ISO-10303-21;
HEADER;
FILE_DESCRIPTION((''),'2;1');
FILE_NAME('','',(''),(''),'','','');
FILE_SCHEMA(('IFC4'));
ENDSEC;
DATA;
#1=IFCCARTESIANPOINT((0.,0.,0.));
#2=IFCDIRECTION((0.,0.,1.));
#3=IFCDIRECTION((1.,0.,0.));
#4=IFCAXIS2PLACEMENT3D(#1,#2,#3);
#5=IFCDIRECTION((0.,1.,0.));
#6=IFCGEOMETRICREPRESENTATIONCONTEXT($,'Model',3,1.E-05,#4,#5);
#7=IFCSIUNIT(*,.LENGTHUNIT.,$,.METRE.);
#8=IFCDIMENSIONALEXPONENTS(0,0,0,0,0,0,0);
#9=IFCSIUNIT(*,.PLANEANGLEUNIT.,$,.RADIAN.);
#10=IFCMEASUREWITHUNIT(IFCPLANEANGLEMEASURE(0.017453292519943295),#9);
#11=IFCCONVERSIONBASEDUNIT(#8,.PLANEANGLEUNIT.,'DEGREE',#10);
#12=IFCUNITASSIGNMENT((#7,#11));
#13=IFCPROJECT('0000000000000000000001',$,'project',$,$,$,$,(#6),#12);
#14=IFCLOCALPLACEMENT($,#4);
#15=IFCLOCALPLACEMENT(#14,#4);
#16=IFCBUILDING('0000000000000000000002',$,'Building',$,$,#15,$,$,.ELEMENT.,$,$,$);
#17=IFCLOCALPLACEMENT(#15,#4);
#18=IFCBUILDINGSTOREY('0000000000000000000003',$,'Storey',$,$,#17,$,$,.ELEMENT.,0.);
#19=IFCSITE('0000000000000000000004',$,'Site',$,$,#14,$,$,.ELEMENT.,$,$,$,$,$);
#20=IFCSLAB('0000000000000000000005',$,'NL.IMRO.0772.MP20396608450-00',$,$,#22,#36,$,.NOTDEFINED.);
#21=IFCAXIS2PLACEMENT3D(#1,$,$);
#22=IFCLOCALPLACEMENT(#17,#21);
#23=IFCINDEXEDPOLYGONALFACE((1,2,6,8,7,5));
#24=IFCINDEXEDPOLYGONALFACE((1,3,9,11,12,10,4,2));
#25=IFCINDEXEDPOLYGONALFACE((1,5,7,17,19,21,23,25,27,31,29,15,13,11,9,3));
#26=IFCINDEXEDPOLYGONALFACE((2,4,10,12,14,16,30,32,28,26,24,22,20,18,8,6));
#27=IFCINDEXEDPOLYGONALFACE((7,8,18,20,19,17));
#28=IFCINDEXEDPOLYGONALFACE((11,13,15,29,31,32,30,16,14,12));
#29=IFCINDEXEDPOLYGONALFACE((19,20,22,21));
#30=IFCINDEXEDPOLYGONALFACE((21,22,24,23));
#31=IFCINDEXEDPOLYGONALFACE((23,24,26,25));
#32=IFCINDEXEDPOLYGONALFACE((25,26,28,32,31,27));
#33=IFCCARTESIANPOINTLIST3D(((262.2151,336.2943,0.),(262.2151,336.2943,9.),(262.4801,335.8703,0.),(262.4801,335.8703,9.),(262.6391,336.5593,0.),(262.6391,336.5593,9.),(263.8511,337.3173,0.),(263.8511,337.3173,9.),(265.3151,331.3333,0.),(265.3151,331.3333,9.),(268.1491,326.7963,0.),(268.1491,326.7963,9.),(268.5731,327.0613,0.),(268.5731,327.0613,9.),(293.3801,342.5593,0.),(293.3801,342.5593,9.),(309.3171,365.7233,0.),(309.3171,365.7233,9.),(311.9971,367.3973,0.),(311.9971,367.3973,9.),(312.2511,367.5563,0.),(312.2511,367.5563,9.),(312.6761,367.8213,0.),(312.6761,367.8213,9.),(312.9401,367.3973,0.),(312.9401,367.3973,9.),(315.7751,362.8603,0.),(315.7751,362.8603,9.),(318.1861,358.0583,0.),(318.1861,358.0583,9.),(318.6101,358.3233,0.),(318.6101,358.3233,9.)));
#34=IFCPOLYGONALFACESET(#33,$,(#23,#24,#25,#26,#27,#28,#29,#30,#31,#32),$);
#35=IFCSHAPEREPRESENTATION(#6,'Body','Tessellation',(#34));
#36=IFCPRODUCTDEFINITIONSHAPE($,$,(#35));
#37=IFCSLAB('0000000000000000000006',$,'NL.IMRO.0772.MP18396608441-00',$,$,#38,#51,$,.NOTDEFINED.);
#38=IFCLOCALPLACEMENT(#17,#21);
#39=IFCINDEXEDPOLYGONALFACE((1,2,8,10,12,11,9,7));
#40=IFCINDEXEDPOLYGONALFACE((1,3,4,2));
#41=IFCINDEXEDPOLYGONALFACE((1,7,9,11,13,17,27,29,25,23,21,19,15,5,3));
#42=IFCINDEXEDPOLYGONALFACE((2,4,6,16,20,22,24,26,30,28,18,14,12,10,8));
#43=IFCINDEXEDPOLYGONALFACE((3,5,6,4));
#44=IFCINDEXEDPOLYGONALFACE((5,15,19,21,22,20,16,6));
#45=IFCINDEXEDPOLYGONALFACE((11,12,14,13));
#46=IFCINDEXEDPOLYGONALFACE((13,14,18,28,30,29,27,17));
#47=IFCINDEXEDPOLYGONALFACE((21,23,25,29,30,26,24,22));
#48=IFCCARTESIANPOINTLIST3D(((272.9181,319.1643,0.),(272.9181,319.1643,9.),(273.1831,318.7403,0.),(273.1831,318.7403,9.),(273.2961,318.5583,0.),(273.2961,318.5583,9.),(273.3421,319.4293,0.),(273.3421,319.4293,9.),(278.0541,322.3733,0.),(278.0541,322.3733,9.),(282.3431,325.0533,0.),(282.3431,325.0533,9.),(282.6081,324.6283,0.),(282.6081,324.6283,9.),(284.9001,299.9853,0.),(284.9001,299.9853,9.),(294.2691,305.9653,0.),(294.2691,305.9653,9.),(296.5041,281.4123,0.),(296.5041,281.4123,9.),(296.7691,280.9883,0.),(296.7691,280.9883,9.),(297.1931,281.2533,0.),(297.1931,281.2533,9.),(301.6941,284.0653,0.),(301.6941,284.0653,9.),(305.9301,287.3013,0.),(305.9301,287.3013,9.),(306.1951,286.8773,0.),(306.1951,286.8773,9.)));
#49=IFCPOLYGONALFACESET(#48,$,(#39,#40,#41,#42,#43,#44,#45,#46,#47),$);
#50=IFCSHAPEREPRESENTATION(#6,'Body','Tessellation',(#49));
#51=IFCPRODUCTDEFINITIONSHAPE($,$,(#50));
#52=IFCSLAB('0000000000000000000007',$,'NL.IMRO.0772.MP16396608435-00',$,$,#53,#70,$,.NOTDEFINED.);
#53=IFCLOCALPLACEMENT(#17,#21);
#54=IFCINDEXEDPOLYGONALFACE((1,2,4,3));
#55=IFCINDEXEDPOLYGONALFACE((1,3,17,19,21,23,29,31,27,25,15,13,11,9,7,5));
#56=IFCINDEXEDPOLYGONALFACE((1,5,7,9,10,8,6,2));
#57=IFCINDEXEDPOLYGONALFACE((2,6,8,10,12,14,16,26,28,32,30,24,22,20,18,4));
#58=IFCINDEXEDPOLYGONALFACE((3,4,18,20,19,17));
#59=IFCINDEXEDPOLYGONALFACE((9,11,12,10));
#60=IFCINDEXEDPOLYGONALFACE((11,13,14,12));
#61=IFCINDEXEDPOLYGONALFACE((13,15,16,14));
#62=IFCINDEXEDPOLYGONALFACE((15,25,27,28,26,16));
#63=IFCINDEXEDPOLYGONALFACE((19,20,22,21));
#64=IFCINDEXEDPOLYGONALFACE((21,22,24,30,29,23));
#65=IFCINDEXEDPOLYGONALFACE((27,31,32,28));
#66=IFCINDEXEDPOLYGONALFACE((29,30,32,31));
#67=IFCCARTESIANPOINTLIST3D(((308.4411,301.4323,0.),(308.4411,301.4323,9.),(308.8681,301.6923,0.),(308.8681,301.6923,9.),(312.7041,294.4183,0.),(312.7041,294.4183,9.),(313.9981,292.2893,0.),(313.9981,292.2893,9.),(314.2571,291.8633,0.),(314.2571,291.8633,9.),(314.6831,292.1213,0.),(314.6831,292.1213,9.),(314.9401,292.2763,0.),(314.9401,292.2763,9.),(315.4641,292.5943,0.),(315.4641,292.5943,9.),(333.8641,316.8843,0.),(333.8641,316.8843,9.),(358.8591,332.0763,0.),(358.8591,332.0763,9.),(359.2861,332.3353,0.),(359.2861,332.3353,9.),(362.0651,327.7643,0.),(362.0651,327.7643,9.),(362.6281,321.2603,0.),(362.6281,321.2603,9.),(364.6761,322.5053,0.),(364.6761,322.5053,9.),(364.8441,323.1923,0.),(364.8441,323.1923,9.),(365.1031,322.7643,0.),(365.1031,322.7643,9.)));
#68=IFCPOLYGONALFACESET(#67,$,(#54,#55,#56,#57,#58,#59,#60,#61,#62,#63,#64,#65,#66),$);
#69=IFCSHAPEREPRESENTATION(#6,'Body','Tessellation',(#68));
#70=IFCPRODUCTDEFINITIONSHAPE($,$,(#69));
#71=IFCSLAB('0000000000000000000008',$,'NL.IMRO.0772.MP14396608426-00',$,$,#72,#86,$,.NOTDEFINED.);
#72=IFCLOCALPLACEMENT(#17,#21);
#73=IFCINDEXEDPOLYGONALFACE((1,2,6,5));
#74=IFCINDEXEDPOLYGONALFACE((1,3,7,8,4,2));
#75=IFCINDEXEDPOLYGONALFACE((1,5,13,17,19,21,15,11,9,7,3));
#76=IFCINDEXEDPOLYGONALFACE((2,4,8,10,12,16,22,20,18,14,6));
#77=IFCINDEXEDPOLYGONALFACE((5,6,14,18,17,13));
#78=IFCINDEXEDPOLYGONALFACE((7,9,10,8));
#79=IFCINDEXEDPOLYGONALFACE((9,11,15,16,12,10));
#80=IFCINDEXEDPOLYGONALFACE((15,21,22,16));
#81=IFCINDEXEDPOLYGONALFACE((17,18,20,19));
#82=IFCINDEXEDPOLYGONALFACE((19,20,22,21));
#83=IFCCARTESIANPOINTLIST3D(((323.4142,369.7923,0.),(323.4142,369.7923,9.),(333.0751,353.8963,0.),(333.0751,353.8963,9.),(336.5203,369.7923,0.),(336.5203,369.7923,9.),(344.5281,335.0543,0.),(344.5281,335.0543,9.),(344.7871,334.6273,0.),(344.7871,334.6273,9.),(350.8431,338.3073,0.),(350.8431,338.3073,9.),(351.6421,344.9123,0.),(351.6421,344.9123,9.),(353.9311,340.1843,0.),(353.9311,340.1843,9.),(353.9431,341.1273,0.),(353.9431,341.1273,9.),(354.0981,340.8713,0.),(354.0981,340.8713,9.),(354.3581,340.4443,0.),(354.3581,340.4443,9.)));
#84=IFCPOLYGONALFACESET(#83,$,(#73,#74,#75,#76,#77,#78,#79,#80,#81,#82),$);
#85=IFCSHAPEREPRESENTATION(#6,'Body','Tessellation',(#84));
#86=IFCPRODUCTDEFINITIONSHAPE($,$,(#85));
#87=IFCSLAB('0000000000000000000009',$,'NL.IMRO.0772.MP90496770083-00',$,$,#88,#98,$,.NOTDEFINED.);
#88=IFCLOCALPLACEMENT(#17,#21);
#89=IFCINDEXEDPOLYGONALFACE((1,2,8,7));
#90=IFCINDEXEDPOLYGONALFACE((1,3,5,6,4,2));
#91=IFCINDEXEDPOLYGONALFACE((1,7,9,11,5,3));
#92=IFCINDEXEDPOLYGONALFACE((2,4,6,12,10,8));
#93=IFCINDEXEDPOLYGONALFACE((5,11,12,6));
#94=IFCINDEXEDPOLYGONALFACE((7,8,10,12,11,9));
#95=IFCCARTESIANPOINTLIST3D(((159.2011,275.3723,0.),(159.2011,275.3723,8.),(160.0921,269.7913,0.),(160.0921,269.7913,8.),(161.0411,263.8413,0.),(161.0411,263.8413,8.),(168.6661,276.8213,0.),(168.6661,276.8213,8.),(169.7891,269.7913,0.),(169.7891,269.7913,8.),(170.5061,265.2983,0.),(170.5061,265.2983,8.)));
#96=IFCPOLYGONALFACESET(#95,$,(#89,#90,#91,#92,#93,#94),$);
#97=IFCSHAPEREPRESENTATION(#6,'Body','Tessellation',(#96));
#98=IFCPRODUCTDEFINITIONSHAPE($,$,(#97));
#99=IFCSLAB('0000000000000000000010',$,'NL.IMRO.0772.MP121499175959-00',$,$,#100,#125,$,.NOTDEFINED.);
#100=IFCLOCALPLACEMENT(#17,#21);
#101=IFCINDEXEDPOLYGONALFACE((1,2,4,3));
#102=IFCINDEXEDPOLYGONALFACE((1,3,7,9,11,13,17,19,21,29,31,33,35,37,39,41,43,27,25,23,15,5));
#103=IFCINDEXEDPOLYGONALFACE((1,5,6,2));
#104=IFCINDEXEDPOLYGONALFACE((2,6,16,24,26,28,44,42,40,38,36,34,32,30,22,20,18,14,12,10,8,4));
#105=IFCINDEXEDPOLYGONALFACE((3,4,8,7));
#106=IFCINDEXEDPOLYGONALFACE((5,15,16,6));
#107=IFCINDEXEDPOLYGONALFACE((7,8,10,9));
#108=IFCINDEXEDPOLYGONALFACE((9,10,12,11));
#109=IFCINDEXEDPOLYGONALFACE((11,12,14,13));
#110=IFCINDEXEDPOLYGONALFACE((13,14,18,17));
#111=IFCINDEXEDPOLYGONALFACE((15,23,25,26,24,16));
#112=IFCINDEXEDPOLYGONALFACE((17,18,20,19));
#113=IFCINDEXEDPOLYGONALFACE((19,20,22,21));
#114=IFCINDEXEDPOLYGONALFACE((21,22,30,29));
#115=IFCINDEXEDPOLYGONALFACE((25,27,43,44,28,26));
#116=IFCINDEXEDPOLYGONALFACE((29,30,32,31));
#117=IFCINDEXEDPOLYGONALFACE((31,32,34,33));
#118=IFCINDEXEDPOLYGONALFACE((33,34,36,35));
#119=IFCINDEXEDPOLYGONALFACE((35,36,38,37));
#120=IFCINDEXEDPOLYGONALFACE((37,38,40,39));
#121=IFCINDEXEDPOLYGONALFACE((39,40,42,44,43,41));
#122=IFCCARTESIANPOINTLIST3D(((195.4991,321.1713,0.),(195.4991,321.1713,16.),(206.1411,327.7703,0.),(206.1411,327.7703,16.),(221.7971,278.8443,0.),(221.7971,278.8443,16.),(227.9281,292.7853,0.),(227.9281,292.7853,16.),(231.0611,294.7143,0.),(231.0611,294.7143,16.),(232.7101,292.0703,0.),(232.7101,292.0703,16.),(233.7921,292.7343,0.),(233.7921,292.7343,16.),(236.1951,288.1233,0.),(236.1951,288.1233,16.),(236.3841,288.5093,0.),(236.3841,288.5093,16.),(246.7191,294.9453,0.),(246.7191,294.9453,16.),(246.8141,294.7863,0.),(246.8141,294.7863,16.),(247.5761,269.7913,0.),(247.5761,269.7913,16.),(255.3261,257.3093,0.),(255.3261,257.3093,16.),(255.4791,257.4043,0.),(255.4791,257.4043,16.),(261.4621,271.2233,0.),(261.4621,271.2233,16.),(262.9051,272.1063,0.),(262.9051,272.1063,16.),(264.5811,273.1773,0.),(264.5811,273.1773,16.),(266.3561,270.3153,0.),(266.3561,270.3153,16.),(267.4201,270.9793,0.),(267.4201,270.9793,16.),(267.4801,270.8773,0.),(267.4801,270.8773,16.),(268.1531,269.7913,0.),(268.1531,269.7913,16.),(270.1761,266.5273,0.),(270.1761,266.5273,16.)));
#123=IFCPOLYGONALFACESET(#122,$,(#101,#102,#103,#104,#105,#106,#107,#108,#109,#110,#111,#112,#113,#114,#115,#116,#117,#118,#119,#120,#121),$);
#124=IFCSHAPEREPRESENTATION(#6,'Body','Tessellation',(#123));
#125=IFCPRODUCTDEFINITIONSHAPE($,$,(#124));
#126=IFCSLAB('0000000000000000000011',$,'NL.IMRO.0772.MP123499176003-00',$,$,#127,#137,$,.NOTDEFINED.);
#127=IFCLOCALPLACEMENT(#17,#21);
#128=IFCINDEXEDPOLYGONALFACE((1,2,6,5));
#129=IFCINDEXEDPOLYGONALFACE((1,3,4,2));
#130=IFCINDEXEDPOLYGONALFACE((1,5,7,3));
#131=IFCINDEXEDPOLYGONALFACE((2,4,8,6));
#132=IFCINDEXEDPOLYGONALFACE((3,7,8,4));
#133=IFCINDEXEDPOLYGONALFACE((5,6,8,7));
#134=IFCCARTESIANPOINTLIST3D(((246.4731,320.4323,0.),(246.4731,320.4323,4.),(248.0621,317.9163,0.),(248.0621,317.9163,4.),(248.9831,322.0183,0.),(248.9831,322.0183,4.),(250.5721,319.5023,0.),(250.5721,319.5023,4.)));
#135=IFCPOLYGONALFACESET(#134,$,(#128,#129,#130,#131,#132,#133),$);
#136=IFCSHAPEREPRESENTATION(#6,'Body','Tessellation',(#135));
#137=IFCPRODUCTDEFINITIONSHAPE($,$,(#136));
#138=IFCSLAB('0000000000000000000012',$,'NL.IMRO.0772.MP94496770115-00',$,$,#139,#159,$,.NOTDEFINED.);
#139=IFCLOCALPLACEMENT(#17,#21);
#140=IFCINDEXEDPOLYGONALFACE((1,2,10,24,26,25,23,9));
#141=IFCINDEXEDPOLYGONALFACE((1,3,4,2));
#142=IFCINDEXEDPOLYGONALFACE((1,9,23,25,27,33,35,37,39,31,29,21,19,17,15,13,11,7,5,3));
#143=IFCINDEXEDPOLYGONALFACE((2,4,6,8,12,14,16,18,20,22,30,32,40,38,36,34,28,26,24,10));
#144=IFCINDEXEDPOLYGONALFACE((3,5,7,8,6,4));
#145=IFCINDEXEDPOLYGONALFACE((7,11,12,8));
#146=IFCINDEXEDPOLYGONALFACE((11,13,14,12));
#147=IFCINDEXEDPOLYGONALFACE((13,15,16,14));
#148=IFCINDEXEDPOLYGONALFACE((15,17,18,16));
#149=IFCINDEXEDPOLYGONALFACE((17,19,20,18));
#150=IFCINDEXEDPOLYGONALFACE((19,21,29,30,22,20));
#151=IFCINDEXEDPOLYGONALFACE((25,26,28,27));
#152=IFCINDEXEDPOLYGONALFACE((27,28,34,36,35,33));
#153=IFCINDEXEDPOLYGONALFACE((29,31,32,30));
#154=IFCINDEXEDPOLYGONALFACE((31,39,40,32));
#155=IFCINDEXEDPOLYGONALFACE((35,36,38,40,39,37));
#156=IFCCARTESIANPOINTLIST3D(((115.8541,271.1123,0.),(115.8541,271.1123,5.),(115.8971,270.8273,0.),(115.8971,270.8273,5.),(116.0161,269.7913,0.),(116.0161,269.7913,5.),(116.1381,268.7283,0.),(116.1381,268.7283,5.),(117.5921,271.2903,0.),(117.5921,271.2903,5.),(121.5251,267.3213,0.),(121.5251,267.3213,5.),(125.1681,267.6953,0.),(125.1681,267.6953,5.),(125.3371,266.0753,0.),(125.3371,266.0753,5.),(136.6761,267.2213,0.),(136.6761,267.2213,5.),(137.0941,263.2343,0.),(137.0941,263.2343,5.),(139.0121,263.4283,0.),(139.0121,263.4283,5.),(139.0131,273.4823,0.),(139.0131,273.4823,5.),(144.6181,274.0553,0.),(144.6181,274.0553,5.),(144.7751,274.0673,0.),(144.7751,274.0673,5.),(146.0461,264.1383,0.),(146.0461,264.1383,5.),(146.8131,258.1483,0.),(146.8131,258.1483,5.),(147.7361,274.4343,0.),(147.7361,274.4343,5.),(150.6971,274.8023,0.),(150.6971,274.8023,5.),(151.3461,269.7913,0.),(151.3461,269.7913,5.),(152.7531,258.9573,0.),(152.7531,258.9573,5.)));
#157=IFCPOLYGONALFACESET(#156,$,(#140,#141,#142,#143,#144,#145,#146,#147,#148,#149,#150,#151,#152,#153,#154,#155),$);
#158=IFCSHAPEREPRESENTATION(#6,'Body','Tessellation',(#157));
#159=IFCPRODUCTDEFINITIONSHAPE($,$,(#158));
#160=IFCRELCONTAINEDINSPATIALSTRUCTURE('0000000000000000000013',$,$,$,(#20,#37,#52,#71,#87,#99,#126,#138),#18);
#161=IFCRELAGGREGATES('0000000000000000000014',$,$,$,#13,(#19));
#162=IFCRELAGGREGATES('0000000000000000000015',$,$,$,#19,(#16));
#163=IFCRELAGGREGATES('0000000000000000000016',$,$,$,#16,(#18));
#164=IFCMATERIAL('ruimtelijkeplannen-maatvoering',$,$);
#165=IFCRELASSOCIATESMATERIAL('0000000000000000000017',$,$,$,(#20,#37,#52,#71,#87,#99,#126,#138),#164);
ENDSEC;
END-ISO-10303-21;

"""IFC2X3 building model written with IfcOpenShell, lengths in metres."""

from ifc_helpers import new_model, entity, si_unit, converted_unit, direction, origin_with_axes, place, context, project, spatial, polyline, outline, extrude, material, element, save


model = new_model("IFC2X3")

# Units and contexts
model_context = context("Model", 3, precision=1e-05, world=origin_with_axes(), true_north=direction((0.0, 1.0, 0.0)))
ifc_project = project(units=[si_unit("LENGTHUNIT", "METRE"), converted_unit("PLANEANGLEUNIT", "DEGREE", entity("IfcPlaneAngleMeasure", 0.017453292519943295), si_unit("PLANEANGLEUNIT", "RADIAN"), dimensions=[0, 0, 0, 0, 0, 0, 0])], contexts=[model_context])

# Site, building, storey
site_placement = place(None, origin_with_axes())
site = spatial("IfcSite", under=ifc_project, at=site_placement, Name="Site", CompositionType="ELEMENT")
building_placement = place(site_placement, origin_with_axes())
building = spatial("IfcBuilding", under=site, at=building_placement, Name="Building", CompositionType="ELEMENT")
storey_placement = place(building_placement, origin_with_axes())
storey = spatial("IfcBuildingStorey", under=building, at=storey_placement, Name="Storey", CompositionType="ELEMENT", Elevation=0.0)

# Slabs
ifc_material = material(Name="ruimtelijkeplannen-maatvoering")
slab_1_placement = place(storey_placement, origin_with_axes())
element("IfcSlab", 1, at=slab_1_placement, inside=storey, material=ifc_material, Name="NL.IMRO.0772.MP20396608450-00", PredefinedType="NOTDEFINED", context=model_context, shape_type="SweptSolid", body=[
    extrude(outline(polyline([(311.9971, 367.3973), (312.2511, 367.5563), (312.6761, 367.8213), (312.9401, 367.3973), (315.7751, 362.8603), (318.6101, 358.3233), (318.1861, 358.0583), (293.3801, 342.5593), (268.5731, 327.0613), (268.1491, 326.7963), (265.3151, 331.3333), (262.4801, 335.8703), (262.2151, 336.2943), (262.6391, 336.5593), (263.8511, 337.3173), (309.3171, 365.7233), (311.9971, 367.3973)])), origin_with_axes(), (0.0, 0.0, 1.0), 9.0),
])
slab_2_placement = place(storey_placement, origin_with_axes())
element("IfcSlab", 2, at=slab_2_placement, inside=storey, material=ifc_material, Name="NL.IMRO.0772.MP18396608441-00", PredefinedType="NOTDEFINED", context=model_context, shape_type="SweptSolid", body=[
    extrude(outline(polyline([(272.9181, 319.1643), (273.3421, 319.4293), (278.0541, 322.3733), (282.3431, 325.0533), (282.6081, 324.6283), (294.2691, 305.9653), (305.9301, 287.3013), (306.1951, 286.8773), (301.6941, 284.0653), (297.1931, 281.2533), (296.7691, 280.9883), (296.5041, 281.4123), (284.9001, 299.9853), (273.2961, 318.5583), (273.1831, 318.7403), (272.9181, 319.1643)])), origin_with_axes(), (0.0, 0.0, 1.0), 9.0),
])
slab_3_placement = place(storey_placement, origin_with_axes())
element("IfcSlab", 3, at=slab_3_placement, inside=storey, material=ifc_material, Name="NL.IMRO.0772.MP16396608435-00", PredefinedType="NOTDEFINED", context=model_context, shape_type="SweptSolid", body=[
    extrude(outline(polyline([(362.6281, 321.2603), (315.4641, 292.5943), (314.9401, 292.2763), (314.6831, 292.1213), (314.2571, 291.8633), (313.9981, 292.2893), (312.7041, 294.4183), (308.4411, 301.4323), (308.8681, 301.6923), (333.8641, 316.8843), (358.8591, 332.0763), (359.2861, 332.3353), (362.0651, 327.7643), (364.8441, 323.1923), (365.1031, 322.7643), (364.6761, 322.5053), (362.6281, 321.2603)])), origin_with_axes(), (0.0, 0.0, 1.0), 9.0),
])
slab_4_placement = place(storey_placement, origin_with_axes())
element("IfcSlab", 4, at=slab_4_placement, inside=storey, material=ifc_material, Name="NL.IMRO.0772.MP14396608426-00", PredefinedType="NOTDEFINED", context=model_context, shape_type="SweptSolid", body=[
    extrude(outline(polyline([(351.6421, 344.9123), (353.9431, 341.1273), (354.0981, 340.8713), (354.3581, 340.4443), (353.9311, 340.1843), (350.8431, 338.3073), (344.7871, 334.6273), (344.5281, 335.0543), (333.0751, 353.8963), (323.4142, 369.7923), (336.5203, 369.7923), (351.6421, 344.9123)])), origin_with_axes(), (0.0, 0.0, 1.0), 9.0),
])
slab_5_placement = place(storey_placement, origin_with_axes())
element("IfcSlab", 5, at=slab_5_placement, inside=storey, material=ifc_material, Name="NL.IMRO.0772.MP90496770083-00", PredefinedType="NOTDEFINED", context=model_context, shape_type="SweptSolid", body=[
    extrude(outline(polyline([(170.5061, 265.2983), (161.0411, 263.8413), (160.0921, 269.7913), (159.2011, 275.3723), (168.6661, 276.8213), (169.7891, 269.7913), (170.5061, 265.2983)])), origin_with_axes(), (0.0, 0.0, 1.0), 8.0),
])
slab_6_placement = place(storey_placement, origin_with_axes())
element("IfcSlab", 6, at=slab_6_placement, inside=storey, material=ifc_material, Name="NL.IMRO.0772.MP121499175959-00", PredefinedType="NOTDEFINED", context=model_context, shape_type="SweptSolid", body=[
    extrude(outline(polyline([(206.1411, 327.7703), (227.9281, 292.7853), (231.0611, 294.7143), (232.7101, 292.0703), (233.7921, 292.7343), (236.3841, 288.5093), (246.7191, 294.9453), (246.8141, 294.7863), (261.4621, 271.2233), (262.9051, 272.1063), (264.5811, 273.1773), (266.3561, 270.3153), (267.4201, 270.9793), (267.4801, 270.8773), (268.1531, 269.7913), (270.1761, 266.5273), (255.4791, 257.4043), (255.3261, 257.3093), (247.5761, 269.7913), (236.1951, 288.1233), (221.7971, 278.8443), (195.4991, 321.1713), (206.1411, 327.7703)])), origin_with_axes(), (0.0, 0.0, 1.0), 16.0),
])
slab_7_placement = place(storey_placement, origin_with_axes())
element("IfcSlab", 7, at=slab_7_placement, inside=storey, material=ifc_material, Name="NL.IMRO.0772.MP123499176003-00", PredefinedType="NOTDEFINED", context=model_context, shape_type="SweptSolid", body=[
    extrude(outline(polyline([(248.0621, 317.9163), (246.4731, 320.4323), (248.9831, 322.0183), (250.5721, 319.5023), (248.0621, 317.9163)])), origin_with_axes(), (0.0, 0.0, 1.0), 4.0),
])
slab_8_placement = place(storey_placement, origin_with_axes())
element("IfcSlab", 8, at=slab_8_placement, inside=storey, material=ifc_material, Name="NL.IMRO.0772.MP94496770115-00", PredefinedType="NOTDEFINED", context=model_context, shape_type="SweptSolid", body=[
    extrude(outline(polyline([(146.8131, 258.1483), (146.0461, 264.1383), (139.0121, 263.4283), (137.0941, 263.2343), (136.6761, 267.2213), (125.3371, 266.0753), (125.1681, 267.6953), (121.5251, 267.3213), (116.1381, 268.7283), (116.0161, 269.7913), (115.8971, 270.8273), (115.8541, 271.1123), (117.5921, 271.2903), (139.0131, 273.4823), (144.6181, 274.0553), (144.7751, 274.0673), (147.7361, 274.4343), (150.6971, 274.8023), (151.3461, 269.7913), (152.7531, 258.9573), (146.8131, 258.1483)])), origin_with_axes(), (0.0, 0.0, 1.0), 5.0),
])

save(model, "model.ifc")
